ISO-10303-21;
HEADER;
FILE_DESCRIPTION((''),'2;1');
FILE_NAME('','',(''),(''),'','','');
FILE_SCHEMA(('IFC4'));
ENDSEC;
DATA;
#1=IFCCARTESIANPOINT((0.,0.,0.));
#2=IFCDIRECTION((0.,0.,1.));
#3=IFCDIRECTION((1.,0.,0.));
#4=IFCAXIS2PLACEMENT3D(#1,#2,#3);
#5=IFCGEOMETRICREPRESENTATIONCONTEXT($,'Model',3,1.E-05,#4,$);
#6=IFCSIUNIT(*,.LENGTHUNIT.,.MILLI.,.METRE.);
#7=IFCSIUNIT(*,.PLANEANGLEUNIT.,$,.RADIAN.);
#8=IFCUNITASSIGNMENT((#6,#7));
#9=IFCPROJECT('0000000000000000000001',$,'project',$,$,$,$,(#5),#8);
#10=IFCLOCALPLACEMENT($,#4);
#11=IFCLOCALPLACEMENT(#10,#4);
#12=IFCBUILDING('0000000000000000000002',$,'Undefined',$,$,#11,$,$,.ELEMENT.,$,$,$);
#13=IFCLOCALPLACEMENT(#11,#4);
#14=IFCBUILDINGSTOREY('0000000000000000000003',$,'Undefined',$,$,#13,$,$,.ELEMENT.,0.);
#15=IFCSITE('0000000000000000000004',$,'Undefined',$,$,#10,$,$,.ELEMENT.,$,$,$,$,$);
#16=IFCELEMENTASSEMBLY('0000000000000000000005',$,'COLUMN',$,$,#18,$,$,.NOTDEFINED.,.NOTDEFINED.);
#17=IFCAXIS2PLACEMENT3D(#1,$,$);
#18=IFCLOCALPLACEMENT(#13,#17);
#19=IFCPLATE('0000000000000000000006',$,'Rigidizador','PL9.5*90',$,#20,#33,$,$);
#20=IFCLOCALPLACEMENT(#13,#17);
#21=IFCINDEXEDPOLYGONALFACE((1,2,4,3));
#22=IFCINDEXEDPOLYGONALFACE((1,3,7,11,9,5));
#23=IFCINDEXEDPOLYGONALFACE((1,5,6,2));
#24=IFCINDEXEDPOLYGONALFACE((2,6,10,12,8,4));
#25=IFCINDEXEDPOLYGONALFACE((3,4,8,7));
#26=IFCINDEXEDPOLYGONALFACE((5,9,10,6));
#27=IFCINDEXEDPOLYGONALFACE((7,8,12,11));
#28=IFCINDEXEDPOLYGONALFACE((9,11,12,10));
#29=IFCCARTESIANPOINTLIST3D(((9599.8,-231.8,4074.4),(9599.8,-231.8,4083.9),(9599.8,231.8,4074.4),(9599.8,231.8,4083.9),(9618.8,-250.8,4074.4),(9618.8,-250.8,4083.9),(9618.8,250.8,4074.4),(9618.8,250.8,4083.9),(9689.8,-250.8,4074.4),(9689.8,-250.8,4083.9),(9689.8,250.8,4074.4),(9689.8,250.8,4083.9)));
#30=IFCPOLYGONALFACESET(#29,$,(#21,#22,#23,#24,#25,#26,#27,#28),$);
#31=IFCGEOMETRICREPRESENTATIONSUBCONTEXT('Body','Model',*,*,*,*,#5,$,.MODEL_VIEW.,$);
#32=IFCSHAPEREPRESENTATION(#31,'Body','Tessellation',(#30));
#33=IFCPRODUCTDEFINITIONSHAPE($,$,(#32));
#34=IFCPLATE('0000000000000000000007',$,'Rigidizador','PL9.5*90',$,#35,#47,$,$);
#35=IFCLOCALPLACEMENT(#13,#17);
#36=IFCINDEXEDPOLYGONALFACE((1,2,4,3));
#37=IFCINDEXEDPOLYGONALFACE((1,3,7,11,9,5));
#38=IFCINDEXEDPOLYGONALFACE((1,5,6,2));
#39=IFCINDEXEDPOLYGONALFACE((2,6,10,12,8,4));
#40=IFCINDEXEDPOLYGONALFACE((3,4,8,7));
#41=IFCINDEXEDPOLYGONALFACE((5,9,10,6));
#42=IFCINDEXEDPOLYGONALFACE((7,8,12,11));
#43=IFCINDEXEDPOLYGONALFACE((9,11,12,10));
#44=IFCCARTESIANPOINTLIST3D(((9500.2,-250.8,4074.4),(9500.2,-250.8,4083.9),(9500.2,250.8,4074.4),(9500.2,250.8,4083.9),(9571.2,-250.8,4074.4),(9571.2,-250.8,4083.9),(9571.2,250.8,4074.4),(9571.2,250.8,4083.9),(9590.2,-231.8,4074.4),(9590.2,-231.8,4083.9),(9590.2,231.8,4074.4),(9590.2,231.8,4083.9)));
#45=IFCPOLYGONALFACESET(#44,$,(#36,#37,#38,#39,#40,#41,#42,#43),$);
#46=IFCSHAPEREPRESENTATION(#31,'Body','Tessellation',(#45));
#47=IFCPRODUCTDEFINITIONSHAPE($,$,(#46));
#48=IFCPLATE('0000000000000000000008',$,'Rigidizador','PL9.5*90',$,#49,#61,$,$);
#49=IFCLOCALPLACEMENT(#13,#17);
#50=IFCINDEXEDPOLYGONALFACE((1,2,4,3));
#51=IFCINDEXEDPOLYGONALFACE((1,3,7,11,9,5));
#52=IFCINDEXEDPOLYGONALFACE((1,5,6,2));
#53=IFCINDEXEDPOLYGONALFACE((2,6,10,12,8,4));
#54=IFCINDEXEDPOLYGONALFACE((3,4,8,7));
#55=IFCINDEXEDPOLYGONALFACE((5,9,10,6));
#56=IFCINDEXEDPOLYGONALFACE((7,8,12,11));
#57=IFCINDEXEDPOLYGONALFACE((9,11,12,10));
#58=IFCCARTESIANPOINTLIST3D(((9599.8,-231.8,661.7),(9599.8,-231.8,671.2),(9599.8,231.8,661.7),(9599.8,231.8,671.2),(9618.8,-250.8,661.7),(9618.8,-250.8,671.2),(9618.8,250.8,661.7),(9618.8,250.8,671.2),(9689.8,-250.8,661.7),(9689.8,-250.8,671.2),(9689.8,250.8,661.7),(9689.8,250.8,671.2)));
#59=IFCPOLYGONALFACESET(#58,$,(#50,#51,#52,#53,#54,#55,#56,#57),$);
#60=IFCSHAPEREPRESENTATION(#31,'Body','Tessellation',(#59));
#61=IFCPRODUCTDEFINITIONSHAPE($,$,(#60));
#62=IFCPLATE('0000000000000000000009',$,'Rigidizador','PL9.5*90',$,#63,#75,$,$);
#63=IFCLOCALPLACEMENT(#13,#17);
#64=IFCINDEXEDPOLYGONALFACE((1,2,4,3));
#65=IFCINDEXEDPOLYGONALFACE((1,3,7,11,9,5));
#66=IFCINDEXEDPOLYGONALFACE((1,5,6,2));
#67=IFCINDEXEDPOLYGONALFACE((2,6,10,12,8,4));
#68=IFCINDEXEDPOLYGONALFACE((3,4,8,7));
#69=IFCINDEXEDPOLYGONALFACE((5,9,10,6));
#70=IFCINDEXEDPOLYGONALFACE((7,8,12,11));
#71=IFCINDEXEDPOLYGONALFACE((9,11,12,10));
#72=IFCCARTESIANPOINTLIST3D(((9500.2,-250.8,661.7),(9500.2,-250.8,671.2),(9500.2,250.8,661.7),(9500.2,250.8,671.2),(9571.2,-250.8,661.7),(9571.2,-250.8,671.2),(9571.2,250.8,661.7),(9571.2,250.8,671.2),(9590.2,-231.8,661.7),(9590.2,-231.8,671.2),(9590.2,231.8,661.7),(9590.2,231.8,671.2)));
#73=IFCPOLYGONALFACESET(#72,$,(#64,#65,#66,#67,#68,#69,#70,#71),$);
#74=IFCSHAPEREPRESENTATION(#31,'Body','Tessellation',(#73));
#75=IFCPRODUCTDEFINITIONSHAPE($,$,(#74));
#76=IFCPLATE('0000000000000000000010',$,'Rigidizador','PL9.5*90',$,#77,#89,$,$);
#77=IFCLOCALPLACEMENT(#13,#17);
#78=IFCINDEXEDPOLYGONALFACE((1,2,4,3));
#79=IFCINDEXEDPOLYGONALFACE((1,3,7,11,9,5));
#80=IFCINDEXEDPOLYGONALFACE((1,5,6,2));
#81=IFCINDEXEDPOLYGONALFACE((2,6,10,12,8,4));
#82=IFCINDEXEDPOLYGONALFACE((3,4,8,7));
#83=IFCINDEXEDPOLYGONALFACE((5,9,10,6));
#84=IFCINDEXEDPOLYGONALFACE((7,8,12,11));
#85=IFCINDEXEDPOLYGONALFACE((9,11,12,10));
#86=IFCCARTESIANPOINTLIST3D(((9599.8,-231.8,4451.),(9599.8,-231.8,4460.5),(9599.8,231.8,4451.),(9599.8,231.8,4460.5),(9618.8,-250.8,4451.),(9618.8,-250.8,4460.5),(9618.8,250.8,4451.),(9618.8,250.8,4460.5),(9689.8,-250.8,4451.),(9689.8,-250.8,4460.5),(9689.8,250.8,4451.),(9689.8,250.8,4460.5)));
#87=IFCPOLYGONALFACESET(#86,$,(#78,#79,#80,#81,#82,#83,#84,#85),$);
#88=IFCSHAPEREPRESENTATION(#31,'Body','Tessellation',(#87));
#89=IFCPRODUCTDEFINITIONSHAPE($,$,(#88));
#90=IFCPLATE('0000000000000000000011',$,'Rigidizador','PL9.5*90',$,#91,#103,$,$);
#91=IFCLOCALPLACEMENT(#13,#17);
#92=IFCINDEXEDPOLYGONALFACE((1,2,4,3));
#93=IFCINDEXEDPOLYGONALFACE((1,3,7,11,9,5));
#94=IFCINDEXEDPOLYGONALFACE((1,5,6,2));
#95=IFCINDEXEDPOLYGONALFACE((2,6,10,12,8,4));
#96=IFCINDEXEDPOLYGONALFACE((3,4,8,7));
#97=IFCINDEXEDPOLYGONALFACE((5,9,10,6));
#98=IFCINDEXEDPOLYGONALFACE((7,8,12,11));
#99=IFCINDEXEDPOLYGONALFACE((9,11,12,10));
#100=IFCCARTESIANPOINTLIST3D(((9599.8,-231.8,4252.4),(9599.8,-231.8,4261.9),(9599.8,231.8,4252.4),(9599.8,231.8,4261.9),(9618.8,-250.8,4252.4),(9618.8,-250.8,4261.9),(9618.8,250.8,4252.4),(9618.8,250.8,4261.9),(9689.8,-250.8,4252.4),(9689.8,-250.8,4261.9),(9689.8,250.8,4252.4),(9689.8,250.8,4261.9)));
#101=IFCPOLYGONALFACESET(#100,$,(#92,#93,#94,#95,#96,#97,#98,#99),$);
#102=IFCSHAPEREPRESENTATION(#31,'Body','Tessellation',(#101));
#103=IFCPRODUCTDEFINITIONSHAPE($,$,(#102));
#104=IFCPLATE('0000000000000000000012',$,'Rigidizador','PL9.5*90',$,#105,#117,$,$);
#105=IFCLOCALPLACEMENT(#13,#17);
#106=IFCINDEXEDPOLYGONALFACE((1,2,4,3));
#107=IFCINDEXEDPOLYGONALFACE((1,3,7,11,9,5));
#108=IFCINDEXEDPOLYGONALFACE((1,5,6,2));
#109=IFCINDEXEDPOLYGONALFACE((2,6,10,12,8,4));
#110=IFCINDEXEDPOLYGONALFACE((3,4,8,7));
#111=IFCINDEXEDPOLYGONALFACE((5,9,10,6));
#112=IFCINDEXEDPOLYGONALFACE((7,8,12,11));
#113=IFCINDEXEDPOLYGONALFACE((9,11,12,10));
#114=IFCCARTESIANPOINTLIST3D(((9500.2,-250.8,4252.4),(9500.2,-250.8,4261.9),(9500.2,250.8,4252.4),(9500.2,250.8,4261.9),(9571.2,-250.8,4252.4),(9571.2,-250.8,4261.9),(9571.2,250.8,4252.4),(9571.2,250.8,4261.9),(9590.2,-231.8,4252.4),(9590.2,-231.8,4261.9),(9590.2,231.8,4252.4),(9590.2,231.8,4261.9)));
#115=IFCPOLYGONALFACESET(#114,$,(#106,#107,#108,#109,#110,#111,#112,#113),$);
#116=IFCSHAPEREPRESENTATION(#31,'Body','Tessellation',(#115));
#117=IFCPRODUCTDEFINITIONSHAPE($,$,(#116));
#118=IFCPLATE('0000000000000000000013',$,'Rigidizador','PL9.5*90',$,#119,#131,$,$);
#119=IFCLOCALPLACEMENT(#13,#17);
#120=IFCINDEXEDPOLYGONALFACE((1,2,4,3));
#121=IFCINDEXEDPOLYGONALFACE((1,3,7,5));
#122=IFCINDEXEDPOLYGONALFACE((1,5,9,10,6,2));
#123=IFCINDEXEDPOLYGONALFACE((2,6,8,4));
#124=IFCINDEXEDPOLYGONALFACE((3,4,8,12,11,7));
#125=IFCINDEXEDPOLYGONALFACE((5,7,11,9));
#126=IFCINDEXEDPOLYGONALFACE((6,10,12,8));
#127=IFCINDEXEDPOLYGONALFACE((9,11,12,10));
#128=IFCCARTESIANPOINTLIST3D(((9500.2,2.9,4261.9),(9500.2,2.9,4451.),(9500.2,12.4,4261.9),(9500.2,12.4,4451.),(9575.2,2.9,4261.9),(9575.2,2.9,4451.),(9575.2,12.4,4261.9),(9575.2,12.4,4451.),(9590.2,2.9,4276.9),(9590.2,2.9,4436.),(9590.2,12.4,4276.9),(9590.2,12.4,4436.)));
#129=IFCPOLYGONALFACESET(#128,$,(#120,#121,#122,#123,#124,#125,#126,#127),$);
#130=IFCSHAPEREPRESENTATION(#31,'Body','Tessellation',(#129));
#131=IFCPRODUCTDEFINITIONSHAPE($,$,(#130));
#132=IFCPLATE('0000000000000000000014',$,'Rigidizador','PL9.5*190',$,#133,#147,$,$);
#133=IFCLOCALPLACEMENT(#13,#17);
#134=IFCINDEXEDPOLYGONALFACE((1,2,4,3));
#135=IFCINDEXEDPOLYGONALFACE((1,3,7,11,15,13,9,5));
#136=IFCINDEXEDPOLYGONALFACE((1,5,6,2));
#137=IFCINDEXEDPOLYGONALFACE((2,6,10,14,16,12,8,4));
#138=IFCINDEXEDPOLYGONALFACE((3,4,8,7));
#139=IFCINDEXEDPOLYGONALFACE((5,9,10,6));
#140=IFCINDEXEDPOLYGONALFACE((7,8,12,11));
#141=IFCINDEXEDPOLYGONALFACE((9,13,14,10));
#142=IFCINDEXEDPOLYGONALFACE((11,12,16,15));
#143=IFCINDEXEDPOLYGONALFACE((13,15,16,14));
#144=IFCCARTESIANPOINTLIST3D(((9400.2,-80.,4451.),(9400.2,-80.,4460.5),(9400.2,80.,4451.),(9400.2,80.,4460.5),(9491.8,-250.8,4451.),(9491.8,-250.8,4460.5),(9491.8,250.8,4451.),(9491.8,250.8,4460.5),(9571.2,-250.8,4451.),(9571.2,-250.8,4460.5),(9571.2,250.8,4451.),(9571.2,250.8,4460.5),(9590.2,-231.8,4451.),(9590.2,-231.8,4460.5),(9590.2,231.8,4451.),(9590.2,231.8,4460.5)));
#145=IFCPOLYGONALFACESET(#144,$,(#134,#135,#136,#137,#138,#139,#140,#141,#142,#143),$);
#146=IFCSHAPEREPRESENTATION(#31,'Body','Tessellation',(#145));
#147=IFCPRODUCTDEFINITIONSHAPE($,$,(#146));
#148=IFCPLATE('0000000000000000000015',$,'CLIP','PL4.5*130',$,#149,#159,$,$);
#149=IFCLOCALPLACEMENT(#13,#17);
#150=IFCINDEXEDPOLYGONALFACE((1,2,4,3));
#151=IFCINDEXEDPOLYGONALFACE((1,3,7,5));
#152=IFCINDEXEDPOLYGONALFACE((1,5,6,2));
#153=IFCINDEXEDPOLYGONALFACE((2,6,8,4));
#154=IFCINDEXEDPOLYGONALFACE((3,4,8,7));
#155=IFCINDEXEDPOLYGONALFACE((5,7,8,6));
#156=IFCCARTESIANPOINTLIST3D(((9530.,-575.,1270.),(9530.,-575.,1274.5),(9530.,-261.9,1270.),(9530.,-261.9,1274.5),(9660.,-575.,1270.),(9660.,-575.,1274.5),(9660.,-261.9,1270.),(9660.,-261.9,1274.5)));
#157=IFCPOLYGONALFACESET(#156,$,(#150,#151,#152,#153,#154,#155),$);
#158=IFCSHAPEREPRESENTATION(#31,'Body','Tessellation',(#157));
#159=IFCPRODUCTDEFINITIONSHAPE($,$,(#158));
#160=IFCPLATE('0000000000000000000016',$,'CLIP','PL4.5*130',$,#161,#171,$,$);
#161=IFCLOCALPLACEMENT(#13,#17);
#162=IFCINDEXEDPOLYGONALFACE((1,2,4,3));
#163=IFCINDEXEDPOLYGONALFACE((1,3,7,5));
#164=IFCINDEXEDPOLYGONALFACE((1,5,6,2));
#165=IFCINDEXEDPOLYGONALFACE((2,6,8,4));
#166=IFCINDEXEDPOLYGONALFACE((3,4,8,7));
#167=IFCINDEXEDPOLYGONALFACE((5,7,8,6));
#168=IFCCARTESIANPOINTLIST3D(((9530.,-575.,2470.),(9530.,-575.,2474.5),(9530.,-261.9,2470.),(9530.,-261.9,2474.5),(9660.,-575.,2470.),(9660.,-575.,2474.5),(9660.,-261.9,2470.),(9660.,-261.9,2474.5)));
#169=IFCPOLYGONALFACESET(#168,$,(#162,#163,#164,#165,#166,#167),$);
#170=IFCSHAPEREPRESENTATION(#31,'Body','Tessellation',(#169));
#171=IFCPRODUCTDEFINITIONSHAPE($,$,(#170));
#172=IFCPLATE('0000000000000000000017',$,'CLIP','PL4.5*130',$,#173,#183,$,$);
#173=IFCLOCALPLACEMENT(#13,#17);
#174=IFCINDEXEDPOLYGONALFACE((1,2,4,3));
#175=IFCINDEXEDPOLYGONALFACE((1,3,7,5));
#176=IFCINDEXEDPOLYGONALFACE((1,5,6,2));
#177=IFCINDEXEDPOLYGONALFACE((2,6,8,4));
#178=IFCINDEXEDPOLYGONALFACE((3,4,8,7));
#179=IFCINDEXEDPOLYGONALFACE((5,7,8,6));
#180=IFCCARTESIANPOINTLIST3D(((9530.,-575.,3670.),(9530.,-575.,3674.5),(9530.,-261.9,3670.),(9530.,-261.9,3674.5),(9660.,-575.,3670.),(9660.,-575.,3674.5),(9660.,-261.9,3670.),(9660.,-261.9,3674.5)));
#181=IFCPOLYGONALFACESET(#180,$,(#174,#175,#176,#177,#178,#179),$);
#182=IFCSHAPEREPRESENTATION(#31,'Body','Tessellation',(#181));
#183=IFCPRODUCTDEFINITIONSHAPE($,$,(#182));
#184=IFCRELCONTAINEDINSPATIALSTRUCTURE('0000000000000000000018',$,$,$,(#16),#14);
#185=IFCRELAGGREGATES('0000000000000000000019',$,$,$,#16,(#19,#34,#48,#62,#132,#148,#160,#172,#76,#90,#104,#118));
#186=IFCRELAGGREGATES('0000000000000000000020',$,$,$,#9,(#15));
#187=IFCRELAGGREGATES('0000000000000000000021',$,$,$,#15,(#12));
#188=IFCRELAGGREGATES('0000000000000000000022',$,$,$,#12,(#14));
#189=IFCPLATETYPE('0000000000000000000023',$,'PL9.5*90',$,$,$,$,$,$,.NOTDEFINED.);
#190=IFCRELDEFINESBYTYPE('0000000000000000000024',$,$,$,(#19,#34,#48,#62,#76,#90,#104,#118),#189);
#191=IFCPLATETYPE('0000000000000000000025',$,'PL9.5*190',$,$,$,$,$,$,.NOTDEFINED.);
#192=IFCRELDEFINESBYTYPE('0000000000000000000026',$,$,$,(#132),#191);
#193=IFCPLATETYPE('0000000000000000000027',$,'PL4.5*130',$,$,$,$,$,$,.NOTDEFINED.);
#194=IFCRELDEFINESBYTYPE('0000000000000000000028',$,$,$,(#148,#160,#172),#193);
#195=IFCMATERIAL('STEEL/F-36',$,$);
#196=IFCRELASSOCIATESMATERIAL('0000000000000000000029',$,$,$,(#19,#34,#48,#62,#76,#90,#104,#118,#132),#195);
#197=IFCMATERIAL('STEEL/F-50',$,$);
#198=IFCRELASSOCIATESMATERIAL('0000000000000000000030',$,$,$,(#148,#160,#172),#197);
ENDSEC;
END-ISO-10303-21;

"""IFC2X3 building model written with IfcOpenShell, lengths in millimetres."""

from ifc_helpers import new_model, si_unit, frame, origin_with_axes, place, context, subcontext, project, spatial, polyline, outline, extrude, material, type_object, element, aggregate, save


model = new_model("IFC2X3")

# Units and contexts
model_context = context("Model", 3, precision=1e-05, world=origin_with_axes())
body_context = subcontext(model_context, "Body", "Model", "MODEL_VIEW")
ifc_project = project(units=[si_unit("LENGTHUNIT", "METRE", prefix="MILLI"), si_unit("PLANEANGLEUNIT", "RADIAN")], contexts=[model_context])

# Site, building, storey
site_placement = place(None, origin_with_axes())
site = spatial("IfcSite", under=ifc_project, at=site_placement, Name="Undefined", CompositionType="ELEMENT")
building_placement = place(site_placement, origin_with_axes())
building = spatial("IfcBuilding", under=site, at=building_placement, Name="Undefined", CompositionType="ELEMENT")
storey_placement = place(building_placement, origin_with_axes())
storey = spatial("IfcBuildingStorey", under=building, at=storey_placement, Name="Undefined", CompositionType="ELEMENT", Elevation=0.0)

# Element assembly
assembly_1_placement = place(storey_placement, origin_with_axes())
assembly_1 = element("IfcElementAssembly", 1, at=assembly_1_placement, inside=storey, Name="COLUMN", AssemblyPlace="NOTDEFINED", PredefinedType="NOTDEFINED")
ifc_material_1 = material(Name="STEEL/F-36")

# Plates
plate_type_1 = type_object("IfcPlateType", Name="PL9.5*90", PredefinedType="NOTDEFINED")
plate_1_placement = place(assembly_1_placement, frame((9689.8, -250.8, 4079.2), z_axis=(0.0, 0.0, -1.0), x_axis=(-1.0, 0.0, 0.0)))
plate_1 = element("IfcPlate", 2, at=plate_1_placement, type_object=plate_type_1, material=ifc_material_1, Name="Rigidizador", Description="PL9.5*90", context=body_context, shape_type="SweptSolid", body=[
    extrude(outline(polyline([(0.0, 0.0), (71.0, 0.0), (90.0, 19.0), (90.0, 482.6), (71.0, 501.6), (0.0, 501.6), (0.0, 0.0)])), frame((0.0, 0.0, -4.8), z_axis=(0.0, 0.0, 1.0), x_axis=(1.0, 0.0, 0.0)), (0.0, 0.0, 1.0), 9.5),
])
plate_2_placement = place(assembly_1_placement, frame((9590.2, -250.8, 4079.2), z_axis=(0.0, 0.0, -1.0), x_axis=(-1.0, 0.0, 0.0)))
plate_2 = element("IfcPlate", 3, at=plate_2_placement, type_object=plate_type_1, material=ifc_material_1, Name="Rigidizador", Description="PL9.5*90", context=body_context, shape_type="SweptSolid", body=[
    extrude(outline(polyline([(0.0, 19.0), (19.0, 0.0), (90.0, 0.0), (90.0, 501.6), (19.0, 501.6), (0.0, 482.6), (0.0, 19.0)])), frame((0.0, 0.0, -4.8), z_axis=(0.0, 0.0, 1.0), x_axis=(1.0, 0.0, 0.0)), (0.0, 0.0, 1.0), 9.5),
])
plate_3_placement = place(assembly_1_placement, frame((9689.8, -250.8, 666.5), z_axis=(0.0, 0.0, -1.0), x_axis=(-1.0, 0.0, 0.0)))
plate_3 = element("IfcPlate", 4, at=plate_3_placement, type_object=plate_type_1, material=ifc_material_1, Name="Rigidizador", Description="PL9.5*90", context=body_context, shape_type="SweptSolid", body=[
    extrude(outline(polyline([(0.0, 0.0), (71.0, 0.0), (90.0, 19.0), (90.0, 482.6), (71.0, 501.6), (0.0, 501.6), (0.0, 0.0)])), frame((0.0, 0.0, -4.8), z_axis=(0.0, 0.0, 1.0), x_axis=(1.0, 0.0, 0.0)), (0.0, 0.0, 1.0), 9.5),
])
plate_4_placement = place(assembly_1_placement, frame((9590.2, -250.8, 666.5), z_axis=(0.0, 0.0, -1.0), x_axis=(-1.0, 0.0, 0.0)))
plate_4 = element("IfcPlate", 5, at=plate_4_placement, type_object=plate_type_1, material=ifc_material_1, Name="Rigidizador", Description="PL9.5*90", context=body_context, shape_type="SweptSolid", body=[
    extrude(outline(polyline([(0.0, 19.0), (19.0, 0.0), (90.0, 0.0), (90.0, 501.6), (19.0, 501.6), (0.0, 482.6), (0.0, 19.0)])), frame((0.0, 0.0, -4.8), z_axis=(0.0, 0.0, 1.0), x_axis=(1.0, 0.0, 0.0)), (0.0, 0.0, 1.0), 9.5),
])
plate_5_placement = place(assembly_1_placement, frame((9689.8, -250.8, 4455.8), z_axis=(0.0, 0.0, -1.0), x_axis=(-1.0, 0.0, 0.0)))
plate_5 = element("IfcPlate", 6, at=plate_5_placement, type_object=plate_type_1, material=ifc_material_1, Name="Rigidizador", Description="PL9.5*90", context=body_context, shape_type="SweptSolid", body=[
    extrude(outline(polyline([(0.0, 0.0), (71.0, 0.0), (90.0, 19.0), (90.0, 482.6), (71.0, 501.6), (0.0, 501.6), (0.0, 0.0)])), frame((0.0, 0.0, -4.8), z_axis=(0.0, 0.0, 1.0), x_axis=(1.0, 0.0, 0.0)), (0.0, 0.0, 1.0), 9.5),
])
plate_6_placement = place(assembly_1_placement, frame((9689.8, -250.8, 4257.2), z_axis=(0.0, 0.0, -1.0), x_axis=(-1.0, 0.0, 0.0)))
plate_6 = element("IfcPlate", 7, at=plate_6_placement, type_object=plate_type_1, material=ifc_material_1, Name="Rigidizador", Description="PL9.5*90", context=body_context, shape_type="SweptSolid", body=[
    extrude(outline(polyline([(0.0, 0.0), (71.0, 0.0), (90.0, 19.0), (90.0, 482.6), (71.0, 501.6), (0.0, 501.6), (0.0, 0.0)])), frame((0.0, 0.0, -4.8), z_axis=(0.0, 0.0, 1.0), x_axis=(1.0, 0.0, 0.0)), (0.0, 0.0, 1.0), 9.5),
])
plate_7_placement = place(assembly_1_placement, frame((9590.2, -250.8, 4257.2), z_axis=(0.0, 0.0, -1.0), x_axis=(-1.0, 0.0, 0.0)))
plate_7 = element("IfcPlate", 8, at=plate_7_placement, type_object=plate_type_1, material=ifc_material_1, Name="Rigidizador", Description="PL9.5*90", context=body_context, shape_type="SweptSolid", body=[
    extrude(outline(polyline([(0.0, 19.0), (19.0, 0.0), (90.0, 0.0), (90.0, 501.6), (19.0, 501.6), (0.0, 482.6), (0.0, 19.0)])), frame((0.0, 0.0, -4.8), z_axis=(0.0, 0.0, 1.0), x_axis=(1.0, 0.0, 0.0)), (0.0, 0.0, 1.0), 9.5),
])
plate_8_placement = place(assembly_1_placement, frame((9500.2, 7.7, 4451.0), z_axis=(0.0, 1.0, 0.0), x_axis=(1.0, 0.0, -0.000004)))
plate_8 = element("IfcPlate", 9, at=plate_8_placement, type_object=plate_type_1, material=ifc_material_1, Name="Rigidizador", Description="PL9.5*90", context=body_context, shape_type="SweptSolid", body=[
    extrude(outline(polyline([(0.0, 0.0), (75.0, 0.0), (90.0, 15.0), (90.0, 174.1), (75.0, 189.1), (0.0, 189.1), (0.0, 0.0)])), frame((0.0, 0.0, -4.8), z_axis=(0.0, 0.0, 1.0), x_axis=(1.0, 0.0, 0.0)), (0.0, 0.0, 1.0), 9.5),
])
plate_type_2 = type_object("IfcPlateType", Name="PL9.5*190", PredefinedType="NOTDEFINED")
plate_9_placement = place(assembly_1_placement, frame((9491.8, 250.8, 4455.8), z_axis=(0.0, 0.0, -1.0), x_axis=(1.0, 0.0, 0.0)))
plate_9 = element("IfcPlate", 10, at=plate_9_placement, type_object=plate_type_2, material=ifc_material_1, Name="Rigidizador", Description="PL9.5*190", context=body_context, shape_type="SweptSolid", body=[
    extrude(outline(polyline([(0.0, 0.0), (79.4, 0.0), (98.4, 19.0), (98.4, 482.6), (79.4, 501.6), (0.0, 501.6), (-91.6, 330.8), (-91.6, 170.8), (0.0, 0.0)])), frame((0.0, 0.0, -4.8), z_axis=(0.0, 0.0, 1.0), x_axis=(1.0, 0.0, 0.0)), (0.0, 0.0, 1.0), 9.5),
])
ifc_material_2 = material(Name="STEEL/F-50")
plate_type_3 = type_object("IfcPlateType", Name="PL4.5*130", PredefinedType="NOTDEFINED")
plate_10_placement = place(assembly_1_placement, frame((9530.0, -575.0, 1272.2), z_axis=(0.0, 0.0, -1.0), x_axis=(0.0, 1.0, 0.0)))
plate_10 = element("IfcPlate", 11, at=plate_10_placement, type_object=plate_type_3, material=ifc_material_2, Name="CLIP", Description="PL4.5*130", context=body_context, shape_type="SweptSolid", body=[
    extrude(outline(polyline([(0.0, 0.0), (313.0, 0.0), (313.1, 130.0), (0.0, 130.0), (0.0, 0.0)])), frame((0.0, 0.0, -2.2), z_axis=(0.0, 0.0, 1.0), x_axis=(1.0, 0.0, 0.0)), (0.0, 0.0, 1.0), 4.5),
])
plate_11_placement = place(assembly_1_placement, frame((9530.0, -575.0, 2472.2), z_axis=(0.0, 0.0, -1.0), x_axis=(0.0, 1.0, 0.0)))
plate_11 = element("IfcPlate", 12, at=plate_11_placement, type_object=plate_type_3, material=ifc_material_2, Name="CLIP", Description="PL4.5*130", context=body_context, shape_type="SweptSolid", body=[
    extrude(outline(polyline([(0.0, 0.0), (313.0, 0.0), (313.1, 130.0), (0.0, 130.0), (0.0, 0.0)])), frame((0.0, 0.0, -2.2), z_axis=(0.0, 0.0, 1.0), x_axis=(1.0, 0.0, 0.0)), (0.0, 0.0, 1.0), 4.5),
])
plate_12_placement = place(assembly_1_placement, frame((9530.0, -575.0, 3672.2), z_axis=(0.0, 0.0, -1.0), x_axis=(0.0, 1.0, 0.0)))
plate_12 = element("IfcPlate", 13, at=plate_12_placement, type_object=plate_type_3, material=ifc_material_2, Name="CLIP", Description="PL4.5*130", context=body_context, shape_type="SweptSolid", body=[
    extrude(outline(polyline([(0.0, 0.0), (313.0, 0.0), (313.1, 130.0), (0.0, 130.0), (0.0, 0.0)])), frame((0.0, 0.0, -2.2), z_axis=(0.0, 0.0, 1.0), x_axis=(1.0, 0.0, 0.0)), (0.0, 0.0, 1.0), 4.5),
])

aggregate(assembly_1, [plate_1, plate_2, plate_3, plate_4, plate_9, plate_10, plate_11, plate_12, plate_5, plate_6, plate_7, plate_8])

save(model, "model.ifc")
